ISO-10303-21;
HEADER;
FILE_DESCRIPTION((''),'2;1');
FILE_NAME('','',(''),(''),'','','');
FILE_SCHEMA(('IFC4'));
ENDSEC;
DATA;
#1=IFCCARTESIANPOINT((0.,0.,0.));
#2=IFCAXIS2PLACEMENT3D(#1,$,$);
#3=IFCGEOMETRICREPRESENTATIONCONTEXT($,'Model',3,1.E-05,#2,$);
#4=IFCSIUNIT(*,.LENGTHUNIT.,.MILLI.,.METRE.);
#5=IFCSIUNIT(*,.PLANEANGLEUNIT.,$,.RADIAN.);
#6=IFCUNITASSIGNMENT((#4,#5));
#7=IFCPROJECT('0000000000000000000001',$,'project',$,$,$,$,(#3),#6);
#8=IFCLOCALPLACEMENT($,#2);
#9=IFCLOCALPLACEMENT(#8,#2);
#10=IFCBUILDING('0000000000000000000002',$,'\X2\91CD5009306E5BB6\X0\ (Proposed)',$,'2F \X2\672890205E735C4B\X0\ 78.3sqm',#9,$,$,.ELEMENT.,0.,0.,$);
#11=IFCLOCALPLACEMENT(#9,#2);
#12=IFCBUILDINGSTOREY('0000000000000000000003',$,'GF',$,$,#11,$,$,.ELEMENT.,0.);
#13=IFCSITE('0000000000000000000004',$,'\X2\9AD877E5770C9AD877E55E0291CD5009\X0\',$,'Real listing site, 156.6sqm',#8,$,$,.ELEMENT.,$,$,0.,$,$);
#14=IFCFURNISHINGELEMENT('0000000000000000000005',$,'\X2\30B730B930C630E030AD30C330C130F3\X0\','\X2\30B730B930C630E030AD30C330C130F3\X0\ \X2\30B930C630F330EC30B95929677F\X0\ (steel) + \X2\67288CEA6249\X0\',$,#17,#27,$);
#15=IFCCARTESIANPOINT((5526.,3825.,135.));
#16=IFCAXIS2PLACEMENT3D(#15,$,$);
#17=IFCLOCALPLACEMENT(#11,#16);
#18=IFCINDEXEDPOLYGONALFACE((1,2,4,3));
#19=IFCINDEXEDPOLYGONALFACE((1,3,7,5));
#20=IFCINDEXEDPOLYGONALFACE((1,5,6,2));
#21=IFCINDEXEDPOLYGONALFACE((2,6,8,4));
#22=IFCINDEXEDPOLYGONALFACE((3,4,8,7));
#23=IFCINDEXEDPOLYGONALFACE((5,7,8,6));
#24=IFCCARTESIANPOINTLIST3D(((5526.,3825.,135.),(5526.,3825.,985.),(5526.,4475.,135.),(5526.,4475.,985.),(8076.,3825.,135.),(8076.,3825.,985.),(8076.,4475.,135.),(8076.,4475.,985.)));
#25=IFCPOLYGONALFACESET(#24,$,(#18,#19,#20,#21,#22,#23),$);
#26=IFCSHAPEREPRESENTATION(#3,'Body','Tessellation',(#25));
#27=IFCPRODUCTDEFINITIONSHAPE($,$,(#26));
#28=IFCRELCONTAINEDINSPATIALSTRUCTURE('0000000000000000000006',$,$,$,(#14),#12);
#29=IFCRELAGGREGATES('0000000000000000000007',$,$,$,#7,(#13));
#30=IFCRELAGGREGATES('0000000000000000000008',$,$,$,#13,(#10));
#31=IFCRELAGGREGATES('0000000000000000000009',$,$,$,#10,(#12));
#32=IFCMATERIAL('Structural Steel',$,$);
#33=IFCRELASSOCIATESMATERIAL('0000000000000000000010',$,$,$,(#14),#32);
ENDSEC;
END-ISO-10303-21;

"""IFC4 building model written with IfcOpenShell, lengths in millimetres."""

from ifc_helpers import new_model, si_unit, frame, frame_2d, origin, place, context, project, spatial, rectangle, extrude, material, element, save


model = new_model("IFC4")

# Units and contexts
model_context = context("Model", 3, precision=1e-05, world=origin())
ifc_project = project(units=[si_unit("LENGTHUNIT", "METRE", prefix="MILLI"), si_unit("PLANEANGLEUNIT", "RADIAN")], contexts=[model_context])

# Site, building, storey
site_placement = place(None, origin())
site = spatial("IfcSite", under=ifc_project, at=site_placement, Name="高知県高知市重倉", ObjectType="Real listing site, 156.6sqm", CompositionType="ELEMENT", RefElevation=0.0)
building_placement = place(site_placement, origin())
building = spatial("IfcBuilding", under=site, at=building_placement, Name="重倉の家 (Proposed)", ObjectType="2F 木造平屋 78.3sqm", CompositionType="ELEMENT", ElevationOfRefHeight=0.0, ElevationOfTerrain=0.0)
storey_placement = place(building_placement, origin())
storey = spatial("IfcBuildingStorey", under=building, at=storey_placement, Name="GF", CompositionType="ELEMENT", Elevation=0.0)

# Furnishing element
ifc_material_1 = material(Name="Structural Steel")
furnishing_1_placement = place(storey_placement, frame((5526.0, 3825.0, 135.0)))
element("IfcFurnishingElement", 1, at=furnishing_1_placement, inside=storey, material=ifc_material_1, Name="システムキッチン", Description="システムキッチン ステンレス天板 (steel) + 木質扉", context=model_context, shape_type="SweptSolid", body=[
    extrude(rectangle(XDim=2550.0, YDim=650.0, at=frame_2d((1275.0, 325.0))), frame((5526.0, 3825.0, 135.0)), (0.0, 0.0, 1.0), 850.0),
])

save(model, "model.ifc")
